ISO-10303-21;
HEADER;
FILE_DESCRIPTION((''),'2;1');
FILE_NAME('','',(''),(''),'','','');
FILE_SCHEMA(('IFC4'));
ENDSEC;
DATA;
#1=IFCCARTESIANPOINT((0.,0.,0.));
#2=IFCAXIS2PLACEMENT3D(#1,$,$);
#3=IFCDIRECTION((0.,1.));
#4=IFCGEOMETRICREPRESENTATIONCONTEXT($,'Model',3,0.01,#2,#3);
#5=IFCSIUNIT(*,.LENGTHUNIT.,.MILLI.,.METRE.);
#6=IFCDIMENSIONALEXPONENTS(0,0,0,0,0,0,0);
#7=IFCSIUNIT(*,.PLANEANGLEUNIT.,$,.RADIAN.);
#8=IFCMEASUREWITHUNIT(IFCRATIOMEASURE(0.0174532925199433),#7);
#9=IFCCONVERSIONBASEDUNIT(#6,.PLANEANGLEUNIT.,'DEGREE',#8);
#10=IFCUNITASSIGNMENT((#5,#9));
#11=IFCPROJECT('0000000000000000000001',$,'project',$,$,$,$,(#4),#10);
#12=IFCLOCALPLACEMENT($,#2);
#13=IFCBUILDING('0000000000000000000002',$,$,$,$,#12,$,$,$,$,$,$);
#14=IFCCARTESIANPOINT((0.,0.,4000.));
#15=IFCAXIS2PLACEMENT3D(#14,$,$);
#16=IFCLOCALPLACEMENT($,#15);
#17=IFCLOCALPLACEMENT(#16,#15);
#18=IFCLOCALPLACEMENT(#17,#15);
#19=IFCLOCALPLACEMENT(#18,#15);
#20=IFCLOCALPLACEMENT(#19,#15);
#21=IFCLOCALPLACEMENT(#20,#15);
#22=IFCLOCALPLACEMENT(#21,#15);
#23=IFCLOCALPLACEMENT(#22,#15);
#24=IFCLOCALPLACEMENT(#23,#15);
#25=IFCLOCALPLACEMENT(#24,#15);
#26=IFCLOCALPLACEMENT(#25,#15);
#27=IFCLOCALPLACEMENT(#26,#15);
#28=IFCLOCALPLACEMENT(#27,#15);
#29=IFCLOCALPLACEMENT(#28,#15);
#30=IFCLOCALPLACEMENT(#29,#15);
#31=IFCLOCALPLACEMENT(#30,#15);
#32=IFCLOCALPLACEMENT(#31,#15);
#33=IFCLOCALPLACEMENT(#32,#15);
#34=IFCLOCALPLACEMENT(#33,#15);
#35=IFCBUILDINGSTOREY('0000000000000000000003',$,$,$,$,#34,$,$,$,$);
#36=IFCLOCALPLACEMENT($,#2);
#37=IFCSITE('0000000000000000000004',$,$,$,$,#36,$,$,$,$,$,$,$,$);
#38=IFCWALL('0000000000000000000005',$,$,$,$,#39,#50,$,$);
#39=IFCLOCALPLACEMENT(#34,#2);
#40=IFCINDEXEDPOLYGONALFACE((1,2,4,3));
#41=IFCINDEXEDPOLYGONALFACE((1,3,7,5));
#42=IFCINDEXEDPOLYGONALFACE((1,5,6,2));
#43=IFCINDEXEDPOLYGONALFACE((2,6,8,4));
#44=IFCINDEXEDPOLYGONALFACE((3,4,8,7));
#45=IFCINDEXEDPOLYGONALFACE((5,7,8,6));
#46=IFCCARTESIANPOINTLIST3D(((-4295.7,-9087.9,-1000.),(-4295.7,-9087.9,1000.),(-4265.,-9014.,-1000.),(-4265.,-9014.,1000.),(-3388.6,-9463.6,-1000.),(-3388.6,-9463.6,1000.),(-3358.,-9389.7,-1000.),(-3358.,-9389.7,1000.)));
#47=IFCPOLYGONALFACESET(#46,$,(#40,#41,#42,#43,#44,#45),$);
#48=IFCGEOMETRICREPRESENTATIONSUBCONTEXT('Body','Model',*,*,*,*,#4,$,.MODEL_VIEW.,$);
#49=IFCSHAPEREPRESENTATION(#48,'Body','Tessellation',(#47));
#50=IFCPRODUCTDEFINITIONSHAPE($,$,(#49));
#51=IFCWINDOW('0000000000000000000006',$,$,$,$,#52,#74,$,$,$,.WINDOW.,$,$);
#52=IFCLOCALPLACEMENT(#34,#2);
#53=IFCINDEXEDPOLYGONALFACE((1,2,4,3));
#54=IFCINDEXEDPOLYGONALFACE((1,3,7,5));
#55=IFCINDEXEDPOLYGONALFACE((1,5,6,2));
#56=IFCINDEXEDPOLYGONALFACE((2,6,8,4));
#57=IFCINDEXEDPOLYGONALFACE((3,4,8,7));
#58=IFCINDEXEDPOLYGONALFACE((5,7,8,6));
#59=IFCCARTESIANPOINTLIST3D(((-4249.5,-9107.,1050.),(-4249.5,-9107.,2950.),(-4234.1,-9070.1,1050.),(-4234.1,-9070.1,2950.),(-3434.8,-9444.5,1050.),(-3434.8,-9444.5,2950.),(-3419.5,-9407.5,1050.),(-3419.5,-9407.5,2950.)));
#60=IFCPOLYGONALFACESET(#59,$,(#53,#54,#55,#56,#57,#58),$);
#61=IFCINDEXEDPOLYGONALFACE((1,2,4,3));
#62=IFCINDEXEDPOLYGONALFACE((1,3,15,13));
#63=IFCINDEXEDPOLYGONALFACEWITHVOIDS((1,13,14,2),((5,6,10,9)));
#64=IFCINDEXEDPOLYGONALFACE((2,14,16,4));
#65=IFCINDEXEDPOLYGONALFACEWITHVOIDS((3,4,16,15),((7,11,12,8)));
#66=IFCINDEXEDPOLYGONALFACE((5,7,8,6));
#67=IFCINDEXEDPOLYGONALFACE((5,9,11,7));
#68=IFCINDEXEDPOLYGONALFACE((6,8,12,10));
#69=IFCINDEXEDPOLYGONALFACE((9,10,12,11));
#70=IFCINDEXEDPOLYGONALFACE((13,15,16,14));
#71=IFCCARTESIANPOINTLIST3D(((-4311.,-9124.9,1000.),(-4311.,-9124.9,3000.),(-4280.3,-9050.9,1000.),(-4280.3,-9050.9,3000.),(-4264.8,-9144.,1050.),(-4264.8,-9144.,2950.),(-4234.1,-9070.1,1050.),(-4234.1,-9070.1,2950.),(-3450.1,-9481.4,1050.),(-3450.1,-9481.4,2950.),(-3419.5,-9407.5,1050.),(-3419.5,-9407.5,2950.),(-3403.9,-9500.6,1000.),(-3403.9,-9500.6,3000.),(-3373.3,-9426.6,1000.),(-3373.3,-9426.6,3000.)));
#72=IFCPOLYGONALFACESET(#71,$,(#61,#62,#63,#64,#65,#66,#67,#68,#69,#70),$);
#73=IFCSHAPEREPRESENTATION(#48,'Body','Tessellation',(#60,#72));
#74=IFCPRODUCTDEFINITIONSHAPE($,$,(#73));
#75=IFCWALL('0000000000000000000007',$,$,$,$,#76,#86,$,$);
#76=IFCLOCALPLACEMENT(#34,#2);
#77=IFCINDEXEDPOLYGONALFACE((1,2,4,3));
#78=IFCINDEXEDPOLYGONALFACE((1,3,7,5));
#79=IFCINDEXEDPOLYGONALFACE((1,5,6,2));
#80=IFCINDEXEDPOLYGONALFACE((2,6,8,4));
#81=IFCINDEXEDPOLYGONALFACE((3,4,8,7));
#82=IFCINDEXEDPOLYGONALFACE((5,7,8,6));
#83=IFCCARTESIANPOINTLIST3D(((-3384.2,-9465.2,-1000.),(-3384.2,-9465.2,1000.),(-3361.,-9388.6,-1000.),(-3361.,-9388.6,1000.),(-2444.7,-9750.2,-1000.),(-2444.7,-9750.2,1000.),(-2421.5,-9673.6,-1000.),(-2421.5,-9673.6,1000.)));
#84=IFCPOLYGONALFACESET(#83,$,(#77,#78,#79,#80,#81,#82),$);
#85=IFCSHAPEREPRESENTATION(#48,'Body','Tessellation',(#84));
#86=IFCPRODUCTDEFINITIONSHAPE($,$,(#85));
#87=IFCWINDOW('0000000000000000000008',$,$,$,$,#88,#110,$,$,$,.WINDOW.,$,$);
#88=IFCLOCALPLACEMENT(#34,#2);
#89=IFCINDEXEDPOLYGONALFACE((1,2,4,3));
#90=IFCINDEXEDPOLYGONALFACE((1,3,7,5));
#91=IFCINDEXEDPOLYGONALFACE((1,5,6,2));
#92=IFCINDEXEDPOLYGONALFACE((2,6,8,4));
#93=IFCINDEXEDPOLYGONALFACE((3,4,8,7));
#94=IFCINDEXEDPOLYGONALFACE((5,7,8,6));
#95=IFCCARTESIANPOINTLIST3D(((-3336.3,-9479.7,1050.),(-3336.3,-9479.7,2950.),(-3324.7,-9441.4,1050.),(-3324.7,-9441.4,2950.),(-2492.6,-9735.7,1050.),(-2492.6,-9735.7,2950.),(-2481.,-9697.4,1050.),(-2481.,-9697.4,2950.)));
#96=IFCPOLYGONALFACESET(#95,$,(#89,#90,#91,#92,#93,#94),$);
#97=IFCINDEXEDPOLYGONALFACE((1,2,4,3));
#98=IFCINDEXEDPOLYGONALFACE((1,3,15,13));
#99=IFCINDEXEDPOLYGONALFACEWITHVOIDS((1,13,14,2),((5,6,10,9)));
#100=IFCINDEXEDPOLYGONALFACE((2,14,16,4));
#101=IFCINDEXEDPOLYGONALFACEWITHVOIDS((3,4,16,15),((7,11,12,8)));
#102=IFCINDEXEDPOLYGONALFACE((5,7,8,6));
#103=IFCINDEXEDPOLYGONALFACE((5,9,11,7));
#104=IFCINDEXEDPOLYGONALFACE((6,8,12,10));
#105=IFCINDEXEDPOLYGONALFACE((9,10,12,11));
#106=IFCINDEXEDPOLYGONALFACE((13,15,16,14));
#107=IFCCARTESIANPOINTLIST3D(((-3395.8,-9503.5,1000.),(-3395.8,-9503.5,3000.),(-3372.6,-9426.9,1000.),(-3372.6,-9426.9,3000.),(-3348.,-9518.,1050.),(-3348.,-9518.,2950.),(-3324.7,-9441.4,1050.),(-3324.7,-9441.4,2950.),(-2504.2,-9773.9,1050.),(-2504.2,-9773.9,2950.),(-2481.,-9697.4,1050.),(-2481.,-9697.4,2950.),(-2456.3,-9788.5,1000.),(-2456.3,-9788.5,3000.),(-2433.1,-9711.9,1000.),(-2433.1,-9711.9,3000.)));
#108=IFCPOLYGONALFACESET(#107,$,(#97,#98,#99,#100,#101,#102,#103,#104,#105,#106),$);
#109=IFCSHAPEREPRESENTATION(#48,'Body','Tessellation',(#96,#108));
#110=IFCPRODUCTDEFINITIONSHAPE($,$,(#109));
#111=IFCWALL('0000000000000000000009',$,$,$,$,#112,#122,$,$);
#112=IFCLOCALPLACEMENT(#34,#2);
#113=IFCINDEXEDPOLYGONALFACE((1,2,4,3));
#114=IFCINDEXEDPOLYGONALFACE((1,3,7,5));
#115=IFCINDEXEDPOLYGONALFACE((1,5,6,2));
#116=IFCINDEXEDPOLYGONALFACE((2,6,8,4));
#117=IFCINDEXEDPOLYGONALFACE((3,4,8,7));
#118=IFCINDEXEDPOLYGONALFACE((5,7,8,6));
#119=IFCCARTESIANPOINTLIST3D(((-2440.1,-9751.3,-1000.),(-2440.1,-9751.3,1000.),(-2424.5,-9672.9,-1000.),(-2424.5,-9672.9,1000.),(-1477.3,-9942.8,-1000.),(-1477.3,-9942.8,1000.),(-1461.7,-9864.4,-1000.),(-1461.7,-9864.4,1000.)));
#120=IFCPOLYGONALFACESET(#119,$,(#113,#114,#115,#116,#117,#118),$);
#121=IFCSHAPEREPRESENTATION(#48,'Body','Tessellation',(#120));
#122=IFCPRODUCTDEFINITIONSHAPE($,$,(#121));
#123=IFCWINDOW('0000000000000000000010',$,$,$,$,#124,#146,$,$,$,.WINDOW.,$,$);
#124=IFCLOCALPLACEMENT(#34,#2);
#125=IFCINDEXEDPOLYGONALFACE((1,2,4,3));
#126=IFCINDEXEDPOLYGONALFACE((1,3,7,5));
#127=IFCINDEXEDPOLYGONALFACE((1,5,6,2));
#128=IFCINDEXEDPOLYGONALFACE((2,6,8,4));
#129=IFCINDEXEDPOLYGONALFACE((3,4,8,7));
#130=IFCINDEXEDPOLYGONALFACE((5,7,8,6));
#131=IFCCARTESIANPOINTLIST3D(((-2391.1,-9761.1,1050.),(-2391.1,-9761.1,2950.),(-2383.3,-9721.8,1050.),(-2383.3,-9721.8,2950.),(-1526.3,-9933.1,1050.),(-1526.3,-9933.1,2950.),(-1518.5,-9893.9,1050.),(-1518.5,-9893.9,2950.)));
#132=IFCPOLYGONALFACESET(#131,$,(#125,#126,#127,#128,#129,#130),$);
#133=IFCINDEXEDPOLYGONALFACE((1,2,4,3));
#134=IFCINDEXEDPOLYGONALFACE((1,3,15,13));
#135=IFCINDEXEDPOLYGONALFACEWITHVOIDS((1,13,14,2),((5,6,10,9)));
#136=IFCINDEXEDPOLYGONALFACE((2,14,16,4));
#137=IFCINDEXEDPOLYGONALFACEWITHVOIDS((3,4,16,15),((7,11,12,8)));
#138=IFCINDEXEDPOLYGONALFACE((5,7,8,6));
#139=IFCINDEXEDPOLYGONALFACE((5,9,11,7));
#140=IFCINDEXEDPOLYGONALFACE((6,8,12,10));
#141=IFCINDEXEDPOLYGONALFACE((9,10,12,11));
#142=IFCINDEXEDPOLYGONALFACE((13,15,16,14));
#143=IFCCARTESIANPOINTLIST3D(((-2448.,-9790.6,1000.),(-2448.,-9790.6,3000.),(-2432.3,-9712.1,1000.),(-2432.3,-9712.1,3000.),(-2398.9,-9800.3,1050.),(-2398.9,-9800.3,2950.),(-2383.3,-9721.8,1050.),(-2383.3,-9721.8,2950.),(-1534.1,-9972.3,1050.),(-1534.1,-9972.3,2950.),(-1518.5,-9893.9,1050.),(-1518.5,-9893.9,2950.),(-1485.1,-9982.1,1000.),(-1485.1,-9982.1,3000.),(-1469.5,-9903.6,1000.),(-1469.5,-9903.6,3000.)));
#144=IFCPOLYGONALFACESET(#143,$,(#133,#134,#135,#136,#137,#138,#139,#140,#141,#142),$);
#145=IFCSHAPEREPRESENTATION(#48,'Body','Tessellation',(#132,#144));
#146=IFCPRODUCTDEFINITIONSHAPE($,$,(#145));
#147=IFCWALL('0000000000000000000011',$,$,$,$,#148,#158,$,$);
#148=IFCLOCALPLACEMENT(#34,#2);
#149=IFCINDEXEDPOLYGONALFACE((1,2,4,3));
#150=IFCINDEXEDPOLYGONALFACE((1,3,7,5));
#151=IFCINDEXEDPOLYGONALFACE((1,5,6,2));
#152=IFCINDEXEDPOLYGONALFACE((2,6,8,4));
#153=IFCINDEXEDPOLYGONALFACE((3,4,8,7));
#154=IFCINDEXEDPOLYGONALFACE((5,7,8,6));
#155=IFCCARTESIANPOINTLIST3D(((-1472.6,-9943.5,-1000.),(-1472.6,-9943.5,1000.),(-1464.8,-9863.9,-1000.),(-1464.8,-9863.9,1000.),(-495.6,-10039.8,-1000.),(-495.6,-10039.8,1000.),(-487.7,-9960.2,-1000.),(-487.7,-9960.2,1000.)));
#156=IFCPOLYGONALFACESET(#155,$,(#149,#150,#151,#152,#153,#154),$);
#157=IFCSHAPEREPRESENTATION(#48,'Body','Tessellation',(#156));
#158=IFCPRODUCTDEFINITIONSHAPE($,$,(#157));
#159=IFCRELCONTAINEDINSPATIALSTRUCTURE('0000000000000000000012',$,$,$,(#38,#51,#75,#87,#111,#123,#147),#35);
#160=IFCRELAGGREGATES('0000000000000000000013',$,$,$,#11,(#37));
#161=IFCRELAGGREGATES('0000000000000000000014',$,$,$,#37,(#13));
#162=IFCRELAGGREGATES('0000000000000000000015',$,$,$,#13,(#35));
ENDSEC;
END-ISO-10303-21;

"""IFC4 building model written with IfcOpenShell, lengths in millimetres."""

from ifc_helpers import new_model, entity, si_unit, converted_unit, direction, frame, origin, origin_2d, place, context, subcontext, project, spatial, rectangle, extrude, element, save


model = new_model("IFC4")

# Units and contexts
model_context = context("Model", 3, precision=0.01, world=origin(), true_north=direction((0.0, 1.0)))
body_context = subcontext(model_context, "Body", "Model", "MODEL_VIEW")
ifc_project = project(units=[si_unit("LENGTHUNIT", "METRE", prefix="MILLI"), converted_unit("PLANEANGLEUNIT", "DEGREE", entity("IfcRatioMeasure", 0.0174532925199433), si_unit("PLANEANGLEUNIT", "RADIAN"), dimensions=[0, 0, 0, 0, 0, 0, 0])], contexts=[model_context])

# Site, building, storey
site_placement = place(None, origin())
site = spatial("IfcSite", under=ifc_project, at=site_placement)
building_placement = place(None, origin())
building = spatial("IfcBuilding", under=site, at=building_placement)
placement_1 = place(None, frame((0.0, 0.0, 4000.0)))
placement_2 = place(placement_1, frame((0.0, 0.0, 4000.0)))
placement_3 = place(placement_2, frame((0.0, 0.0, 4000.0)))
placement_4 = place(placement_3, frame((0.0, 0.0, 4000.0)))
placement_5 = place(placement_4, frame((0.0, 0.0, 4000.0)))
placement_6 = place(placement_5, frame((0.0, 0.0, 4000.0)))
placement_7 = place(placement_6, frame((0.0, 0.0, 4000.0)))
placement_8 = place(placement_7, frame((0.0, 0.0, 4000.0)))
placement_9 = place(placement_8, frame((0.0, 0.0, 4000.0)))
placement_10 = place(placement_9, frame((0.0, 0.0, 4000.0)))
placement_11 = place(placement_10, frame((0.0, 0.0, 4000.0)))
placement_12 = place(placement_11, frame((0.0, 0.0, 4000.0)))
placement_13 = place(placement_12, frame((0.0, 0.0, 4000.0)))
placement_14 = place(placement_13, frame((0.0, 0.0, 4000.0)))
placement_15 = place(placement_14, frame((0.0, 0.0, 4000.0)))
placement_16 = place(placement_15, frame((0.0, 0.0, 4000.0)))
placement_17 = place(placement_16, frame((0.0, 0.0, 4000.0)))
placement_18 = place(placement_17, frame((0.0, 0.0, 4000.0)))
storey_placement = place(placement_18, frame((0.0, 0.0, 4000.0)))
storey = spatial("IfcBuildingStorey", under=building, at=storey_placement)

# Shared definitions
cartesian_point_1 = entity("IfcCartesianPoint", [-440.9, -950.0])
shared_polyline = entity("IfcPolyline", [cartesian_point_1, entity("IfcCartesianPoint", [-440.9, 950.0]), entity("IfcCartesianPoint", [-440.9, 950.0]), entity("IfcCartesianPoint", [440.9, 950.0]), entity("IfcCartesianPoint", [440.9, 950.0]), entity("IfcCartesianPoint", [440.9, -950.0]), entity("IfcCartesianPoint", [440.9, -950.0]), entity("IfcCartesianPoint", [-440.9, -950.0]), cartesian_point_1])

# Wall
wall_1_placement = place(storey_placement, frame((-3826.8, -9238.8, -1000.0), z_axis=(0.0, 0.0, 1.0), x_axis=(9238.794759, -3826.835691, 0.0)))
element("IfcWall", 1, at=wall_1_placement, inside=storey, context=body_context, shape_type="SweptSolid", body=[
    extrude(rectangle(XDim=981.7, YDim=80.0, at=origin_2d()), origin(), (0.0, 0.0, 1.0), 2000.0),
])

# Window
window_1_placement = place(storey_placement, frame((-3826.8, -9238.8, 2000.0), z_axis=(0.0, 0.0, 1.0), x_axis=(9238.794759, -3826.835691, 0.0)))
cartesian_point_2 = entity("IfcCartesianPoint", [-490.9, -1000.0])
element("IfcWindow", 2, at=window_1_placement, inside=storey, PredefinedType="WINDOW", context=body_context, shape_type="SweptSolid", body=[
    entity("IfcExtrudedAreaSolid", entity("IfcArbitraryClosedProfileDef", "AREA", None, shared_polyline), entity("IfcAxis2Placement3D", entity("IfcCartesianPoint", [0.0, 0.0, 0.0]), entity("IfcDirection", [0.0, -1.0, 0.0]), entity("IfcDirection", [1.0, 0.0, 0.0])), entity("IfcDirection", [0.0, 0.0, 1.0]), 40.0),
    entity("IfcExtrudedAreaSolid", entity("IfcArbitraryProfileDefWithVoids", "AREA", None, entity("IfcPolyline", [cartesian_point_2, entity("IfcCartesianPoint", [-490.9, 1000.0]), entity("IfcCartesianPoint", [-490.9, 1000.0]), entity("IfcCartesianPoint", [490.9, 1000.0]), entity("IfcCartesianPoint", [490.9, 1000.0]), entity("IfcCartesianPoint", [490.9, -1000.0]), entity("IfcCartesianPoint", [490.9, -1000.0]), entity("IfcCartesianPoint", [-490.9, -1000.0]), cartesian_point_2]), [shared_polyline]), entity("IfcAxis2Placement3D", entity("IfcCartesianPoint", [0.0, 0.0, 0.0]), entity("IfcDirection", [0.0, -1.0, 0.0]), entity("IfcDirection", [1.0, 0.0, 0.0])), entity("IfcDirection", [0.0, 0.0, 1.0]), 80.0),
])

# Wall
wall_2_placement = place(storey_placement, frame((-2902.8, -9569.4, -1000.0), z_axis=(0.0, 0.0, 1.0), x_axis=(9569.403736, -2902.845525, 0.0)))
element("IfcWall", 3, at=wall_2_placement, inside=storey, context=body_context, shape_type="SweptSolid", body=[
    extrude(rectangle(XDim=981.7, YDim=80.0, at=origin_2d()), origin(), (0.0, 0.0, 1.0), 2000.0),
])

# Window
window_2_placement = place(storey_placement, frame((-2902.8, -9569.4, 2000.0), z_axis=(0.0, 0.0, 1.0), x_axis=(9569.403736, -2902.845525, 0.0)))
cartesian_point_3 = entity("IfcCartesianPoint", [-490.9, -1000.0])
element("IfcWindow", 4, at=window_2_placement, inside=storey, PredefinedType="WINDOW", context=body_context, shape_type="SweptSolid", body=[
    entity("IfcExtrudedAreaSolid", entity("IfcArbitraryClosedProfileDef", "AREA", None, shared_polyline), entity("IfcAxis2Placement3D", entity("IfcCartesianPoint", [0.0, 0.0, 0.0]), entity("IfcDirection", [0.0, -1.0, 0.0]), entity("IfcDirection", [1.0, 0.0, 0.0])), entity("IfcDirection", [0.0, 0.0, 1.0]), 40.0),
    entity("IfcExtrudedAreaSolid", entity("IfcArbitraryProfileDefWithVoids", "AREA", None, entity("IfcPolyline", [cartesian_point_3, entity("IfcCartesianPoint", [-490.9, 1000.0]), entity("IfcCartesianPoint", [-490.9, 1000.0]), entity("IfcCartesianPoint", [490.9, 1000.0]), entity("IfcCartesianPoint", [490.9, 1000.0]), entity("IfcCartesianPoint", [490.9, -1000.0]), entity("IfcCartesianPoint", [490.9, -1000.0]), entity("IfcCartesianPoint", [-490.9, -1000.0]), cartesian_point_3]), [shared_polyline]), entity("IfcAxis2Placement3D", entity("IfcCartesianPoint", [0.0, 0.0, 0.0]), entity("IfcDirection", [0.0, -1.0, 0.0]), entity("IfcDirection", [1.0, 0.0, 0.0])), entity("IfcDirection", [0.0, 0.0, 1.0]), 80.0),
])

# Wall
wall_3_placement = place(storey_placement, frame((-1950.9, -9807.9, -1000.0), z_axis=(0.0, 0.0, 1.0), x_axis=(9807.852671, -1950.903888, 0.0)))
element("IfcWall", 5, at=wall_3_placement, inside=storey, context=body_context, shape_type="SweptSolid", body=[
    extrude(rectangle(XDim=981.7, YDim=80.0, at=origin_2d()), origin(), (0.0, 0.0, 1.0), 2000.0),
])

# Window
window_3_placement = place(storey_placement, frame((-1950.9, -9807.9, 2000.0), z_axis=(0.0, 0.0, 1.0), x_axis=(9807.852671, -1950.903888, 0.0)))
cartesian_point_4 = entity("IfcCartesianPoint", [-490.9, -1000.0])
element("IfcWindow", 6, at=window_3_placement, inside=storey, PredefinedType="WINDOW", context=body_context, shape_type="SweptSolid", body=[
    entity("IfcExtrudedAreaSolid", entity("IfcArbitraryClosedProfileDef", "AREA", None, shared_polyline), entity("IfcAxis2Placement3D", entity("IfcCartesianPoint", [0.0, 0.0, 0.0]), entity("IfcDirection", [0.0, -1.0, 0.0]), entity("IfcDirection", [1.0, 0.0, 0.0])), entity("IfcDirection", [0.0, 0.0, 1.0]), 40.0),
    entity("IfcExtrudedAreaSolid", entity("IfcArbitraryProfileDefWithVoids", "AREA", None, entity("IfcPolyline", [cartesian_point_4, entity("IfcCartesianPoint", [-490.9, 1000.0]), entity("IfcCartesianPoint", [-490.9, 1000.0]), entity("IfcCartesianPoint", [490.9, 1000.0]), entity("IfcCartesianPoint", [490.9, 1000.0]), entity("IfcCartesianPoint", [490.9, -1000.0]), entity("IfcCartesianPoint", [490.9, -1000.0]), entity("IfcCartesianPoint", [-490.9, -1000.0]), cartesian_point_4]), [shared_polyline]), entity("IfcAxis2Placement3D", entity("IfcCartesianPoint", [0.0, 0.0, 0.0]), entity("IfcDirection", [0.0, -1.0, 0.0]), entity("IfcDirection", [1.0, 0.0, 0.0])), entity("IfcDirection", [0.0, 0.0, 1.0]), 80.0),
])

# Wall
wall_4_placement = place(storey_placement, frame((-980.2, -9951.8, -1000.0), z_axis=(0.0, 0.0, 1.0), x_axis=(9951.847473, -980.16931, 0.0)))
element("IfcWall", 7, at=wall_4_placement, inside=storey, context=body_context, shape_type="SweptSolid", body=[
    extrude(rectangle(XDim=981.7, YDim=80.0, at=origin_2d()), origin(), (0.0, 0.0, 1.0), 2000.0),
])

save(model, "model.ifc")
